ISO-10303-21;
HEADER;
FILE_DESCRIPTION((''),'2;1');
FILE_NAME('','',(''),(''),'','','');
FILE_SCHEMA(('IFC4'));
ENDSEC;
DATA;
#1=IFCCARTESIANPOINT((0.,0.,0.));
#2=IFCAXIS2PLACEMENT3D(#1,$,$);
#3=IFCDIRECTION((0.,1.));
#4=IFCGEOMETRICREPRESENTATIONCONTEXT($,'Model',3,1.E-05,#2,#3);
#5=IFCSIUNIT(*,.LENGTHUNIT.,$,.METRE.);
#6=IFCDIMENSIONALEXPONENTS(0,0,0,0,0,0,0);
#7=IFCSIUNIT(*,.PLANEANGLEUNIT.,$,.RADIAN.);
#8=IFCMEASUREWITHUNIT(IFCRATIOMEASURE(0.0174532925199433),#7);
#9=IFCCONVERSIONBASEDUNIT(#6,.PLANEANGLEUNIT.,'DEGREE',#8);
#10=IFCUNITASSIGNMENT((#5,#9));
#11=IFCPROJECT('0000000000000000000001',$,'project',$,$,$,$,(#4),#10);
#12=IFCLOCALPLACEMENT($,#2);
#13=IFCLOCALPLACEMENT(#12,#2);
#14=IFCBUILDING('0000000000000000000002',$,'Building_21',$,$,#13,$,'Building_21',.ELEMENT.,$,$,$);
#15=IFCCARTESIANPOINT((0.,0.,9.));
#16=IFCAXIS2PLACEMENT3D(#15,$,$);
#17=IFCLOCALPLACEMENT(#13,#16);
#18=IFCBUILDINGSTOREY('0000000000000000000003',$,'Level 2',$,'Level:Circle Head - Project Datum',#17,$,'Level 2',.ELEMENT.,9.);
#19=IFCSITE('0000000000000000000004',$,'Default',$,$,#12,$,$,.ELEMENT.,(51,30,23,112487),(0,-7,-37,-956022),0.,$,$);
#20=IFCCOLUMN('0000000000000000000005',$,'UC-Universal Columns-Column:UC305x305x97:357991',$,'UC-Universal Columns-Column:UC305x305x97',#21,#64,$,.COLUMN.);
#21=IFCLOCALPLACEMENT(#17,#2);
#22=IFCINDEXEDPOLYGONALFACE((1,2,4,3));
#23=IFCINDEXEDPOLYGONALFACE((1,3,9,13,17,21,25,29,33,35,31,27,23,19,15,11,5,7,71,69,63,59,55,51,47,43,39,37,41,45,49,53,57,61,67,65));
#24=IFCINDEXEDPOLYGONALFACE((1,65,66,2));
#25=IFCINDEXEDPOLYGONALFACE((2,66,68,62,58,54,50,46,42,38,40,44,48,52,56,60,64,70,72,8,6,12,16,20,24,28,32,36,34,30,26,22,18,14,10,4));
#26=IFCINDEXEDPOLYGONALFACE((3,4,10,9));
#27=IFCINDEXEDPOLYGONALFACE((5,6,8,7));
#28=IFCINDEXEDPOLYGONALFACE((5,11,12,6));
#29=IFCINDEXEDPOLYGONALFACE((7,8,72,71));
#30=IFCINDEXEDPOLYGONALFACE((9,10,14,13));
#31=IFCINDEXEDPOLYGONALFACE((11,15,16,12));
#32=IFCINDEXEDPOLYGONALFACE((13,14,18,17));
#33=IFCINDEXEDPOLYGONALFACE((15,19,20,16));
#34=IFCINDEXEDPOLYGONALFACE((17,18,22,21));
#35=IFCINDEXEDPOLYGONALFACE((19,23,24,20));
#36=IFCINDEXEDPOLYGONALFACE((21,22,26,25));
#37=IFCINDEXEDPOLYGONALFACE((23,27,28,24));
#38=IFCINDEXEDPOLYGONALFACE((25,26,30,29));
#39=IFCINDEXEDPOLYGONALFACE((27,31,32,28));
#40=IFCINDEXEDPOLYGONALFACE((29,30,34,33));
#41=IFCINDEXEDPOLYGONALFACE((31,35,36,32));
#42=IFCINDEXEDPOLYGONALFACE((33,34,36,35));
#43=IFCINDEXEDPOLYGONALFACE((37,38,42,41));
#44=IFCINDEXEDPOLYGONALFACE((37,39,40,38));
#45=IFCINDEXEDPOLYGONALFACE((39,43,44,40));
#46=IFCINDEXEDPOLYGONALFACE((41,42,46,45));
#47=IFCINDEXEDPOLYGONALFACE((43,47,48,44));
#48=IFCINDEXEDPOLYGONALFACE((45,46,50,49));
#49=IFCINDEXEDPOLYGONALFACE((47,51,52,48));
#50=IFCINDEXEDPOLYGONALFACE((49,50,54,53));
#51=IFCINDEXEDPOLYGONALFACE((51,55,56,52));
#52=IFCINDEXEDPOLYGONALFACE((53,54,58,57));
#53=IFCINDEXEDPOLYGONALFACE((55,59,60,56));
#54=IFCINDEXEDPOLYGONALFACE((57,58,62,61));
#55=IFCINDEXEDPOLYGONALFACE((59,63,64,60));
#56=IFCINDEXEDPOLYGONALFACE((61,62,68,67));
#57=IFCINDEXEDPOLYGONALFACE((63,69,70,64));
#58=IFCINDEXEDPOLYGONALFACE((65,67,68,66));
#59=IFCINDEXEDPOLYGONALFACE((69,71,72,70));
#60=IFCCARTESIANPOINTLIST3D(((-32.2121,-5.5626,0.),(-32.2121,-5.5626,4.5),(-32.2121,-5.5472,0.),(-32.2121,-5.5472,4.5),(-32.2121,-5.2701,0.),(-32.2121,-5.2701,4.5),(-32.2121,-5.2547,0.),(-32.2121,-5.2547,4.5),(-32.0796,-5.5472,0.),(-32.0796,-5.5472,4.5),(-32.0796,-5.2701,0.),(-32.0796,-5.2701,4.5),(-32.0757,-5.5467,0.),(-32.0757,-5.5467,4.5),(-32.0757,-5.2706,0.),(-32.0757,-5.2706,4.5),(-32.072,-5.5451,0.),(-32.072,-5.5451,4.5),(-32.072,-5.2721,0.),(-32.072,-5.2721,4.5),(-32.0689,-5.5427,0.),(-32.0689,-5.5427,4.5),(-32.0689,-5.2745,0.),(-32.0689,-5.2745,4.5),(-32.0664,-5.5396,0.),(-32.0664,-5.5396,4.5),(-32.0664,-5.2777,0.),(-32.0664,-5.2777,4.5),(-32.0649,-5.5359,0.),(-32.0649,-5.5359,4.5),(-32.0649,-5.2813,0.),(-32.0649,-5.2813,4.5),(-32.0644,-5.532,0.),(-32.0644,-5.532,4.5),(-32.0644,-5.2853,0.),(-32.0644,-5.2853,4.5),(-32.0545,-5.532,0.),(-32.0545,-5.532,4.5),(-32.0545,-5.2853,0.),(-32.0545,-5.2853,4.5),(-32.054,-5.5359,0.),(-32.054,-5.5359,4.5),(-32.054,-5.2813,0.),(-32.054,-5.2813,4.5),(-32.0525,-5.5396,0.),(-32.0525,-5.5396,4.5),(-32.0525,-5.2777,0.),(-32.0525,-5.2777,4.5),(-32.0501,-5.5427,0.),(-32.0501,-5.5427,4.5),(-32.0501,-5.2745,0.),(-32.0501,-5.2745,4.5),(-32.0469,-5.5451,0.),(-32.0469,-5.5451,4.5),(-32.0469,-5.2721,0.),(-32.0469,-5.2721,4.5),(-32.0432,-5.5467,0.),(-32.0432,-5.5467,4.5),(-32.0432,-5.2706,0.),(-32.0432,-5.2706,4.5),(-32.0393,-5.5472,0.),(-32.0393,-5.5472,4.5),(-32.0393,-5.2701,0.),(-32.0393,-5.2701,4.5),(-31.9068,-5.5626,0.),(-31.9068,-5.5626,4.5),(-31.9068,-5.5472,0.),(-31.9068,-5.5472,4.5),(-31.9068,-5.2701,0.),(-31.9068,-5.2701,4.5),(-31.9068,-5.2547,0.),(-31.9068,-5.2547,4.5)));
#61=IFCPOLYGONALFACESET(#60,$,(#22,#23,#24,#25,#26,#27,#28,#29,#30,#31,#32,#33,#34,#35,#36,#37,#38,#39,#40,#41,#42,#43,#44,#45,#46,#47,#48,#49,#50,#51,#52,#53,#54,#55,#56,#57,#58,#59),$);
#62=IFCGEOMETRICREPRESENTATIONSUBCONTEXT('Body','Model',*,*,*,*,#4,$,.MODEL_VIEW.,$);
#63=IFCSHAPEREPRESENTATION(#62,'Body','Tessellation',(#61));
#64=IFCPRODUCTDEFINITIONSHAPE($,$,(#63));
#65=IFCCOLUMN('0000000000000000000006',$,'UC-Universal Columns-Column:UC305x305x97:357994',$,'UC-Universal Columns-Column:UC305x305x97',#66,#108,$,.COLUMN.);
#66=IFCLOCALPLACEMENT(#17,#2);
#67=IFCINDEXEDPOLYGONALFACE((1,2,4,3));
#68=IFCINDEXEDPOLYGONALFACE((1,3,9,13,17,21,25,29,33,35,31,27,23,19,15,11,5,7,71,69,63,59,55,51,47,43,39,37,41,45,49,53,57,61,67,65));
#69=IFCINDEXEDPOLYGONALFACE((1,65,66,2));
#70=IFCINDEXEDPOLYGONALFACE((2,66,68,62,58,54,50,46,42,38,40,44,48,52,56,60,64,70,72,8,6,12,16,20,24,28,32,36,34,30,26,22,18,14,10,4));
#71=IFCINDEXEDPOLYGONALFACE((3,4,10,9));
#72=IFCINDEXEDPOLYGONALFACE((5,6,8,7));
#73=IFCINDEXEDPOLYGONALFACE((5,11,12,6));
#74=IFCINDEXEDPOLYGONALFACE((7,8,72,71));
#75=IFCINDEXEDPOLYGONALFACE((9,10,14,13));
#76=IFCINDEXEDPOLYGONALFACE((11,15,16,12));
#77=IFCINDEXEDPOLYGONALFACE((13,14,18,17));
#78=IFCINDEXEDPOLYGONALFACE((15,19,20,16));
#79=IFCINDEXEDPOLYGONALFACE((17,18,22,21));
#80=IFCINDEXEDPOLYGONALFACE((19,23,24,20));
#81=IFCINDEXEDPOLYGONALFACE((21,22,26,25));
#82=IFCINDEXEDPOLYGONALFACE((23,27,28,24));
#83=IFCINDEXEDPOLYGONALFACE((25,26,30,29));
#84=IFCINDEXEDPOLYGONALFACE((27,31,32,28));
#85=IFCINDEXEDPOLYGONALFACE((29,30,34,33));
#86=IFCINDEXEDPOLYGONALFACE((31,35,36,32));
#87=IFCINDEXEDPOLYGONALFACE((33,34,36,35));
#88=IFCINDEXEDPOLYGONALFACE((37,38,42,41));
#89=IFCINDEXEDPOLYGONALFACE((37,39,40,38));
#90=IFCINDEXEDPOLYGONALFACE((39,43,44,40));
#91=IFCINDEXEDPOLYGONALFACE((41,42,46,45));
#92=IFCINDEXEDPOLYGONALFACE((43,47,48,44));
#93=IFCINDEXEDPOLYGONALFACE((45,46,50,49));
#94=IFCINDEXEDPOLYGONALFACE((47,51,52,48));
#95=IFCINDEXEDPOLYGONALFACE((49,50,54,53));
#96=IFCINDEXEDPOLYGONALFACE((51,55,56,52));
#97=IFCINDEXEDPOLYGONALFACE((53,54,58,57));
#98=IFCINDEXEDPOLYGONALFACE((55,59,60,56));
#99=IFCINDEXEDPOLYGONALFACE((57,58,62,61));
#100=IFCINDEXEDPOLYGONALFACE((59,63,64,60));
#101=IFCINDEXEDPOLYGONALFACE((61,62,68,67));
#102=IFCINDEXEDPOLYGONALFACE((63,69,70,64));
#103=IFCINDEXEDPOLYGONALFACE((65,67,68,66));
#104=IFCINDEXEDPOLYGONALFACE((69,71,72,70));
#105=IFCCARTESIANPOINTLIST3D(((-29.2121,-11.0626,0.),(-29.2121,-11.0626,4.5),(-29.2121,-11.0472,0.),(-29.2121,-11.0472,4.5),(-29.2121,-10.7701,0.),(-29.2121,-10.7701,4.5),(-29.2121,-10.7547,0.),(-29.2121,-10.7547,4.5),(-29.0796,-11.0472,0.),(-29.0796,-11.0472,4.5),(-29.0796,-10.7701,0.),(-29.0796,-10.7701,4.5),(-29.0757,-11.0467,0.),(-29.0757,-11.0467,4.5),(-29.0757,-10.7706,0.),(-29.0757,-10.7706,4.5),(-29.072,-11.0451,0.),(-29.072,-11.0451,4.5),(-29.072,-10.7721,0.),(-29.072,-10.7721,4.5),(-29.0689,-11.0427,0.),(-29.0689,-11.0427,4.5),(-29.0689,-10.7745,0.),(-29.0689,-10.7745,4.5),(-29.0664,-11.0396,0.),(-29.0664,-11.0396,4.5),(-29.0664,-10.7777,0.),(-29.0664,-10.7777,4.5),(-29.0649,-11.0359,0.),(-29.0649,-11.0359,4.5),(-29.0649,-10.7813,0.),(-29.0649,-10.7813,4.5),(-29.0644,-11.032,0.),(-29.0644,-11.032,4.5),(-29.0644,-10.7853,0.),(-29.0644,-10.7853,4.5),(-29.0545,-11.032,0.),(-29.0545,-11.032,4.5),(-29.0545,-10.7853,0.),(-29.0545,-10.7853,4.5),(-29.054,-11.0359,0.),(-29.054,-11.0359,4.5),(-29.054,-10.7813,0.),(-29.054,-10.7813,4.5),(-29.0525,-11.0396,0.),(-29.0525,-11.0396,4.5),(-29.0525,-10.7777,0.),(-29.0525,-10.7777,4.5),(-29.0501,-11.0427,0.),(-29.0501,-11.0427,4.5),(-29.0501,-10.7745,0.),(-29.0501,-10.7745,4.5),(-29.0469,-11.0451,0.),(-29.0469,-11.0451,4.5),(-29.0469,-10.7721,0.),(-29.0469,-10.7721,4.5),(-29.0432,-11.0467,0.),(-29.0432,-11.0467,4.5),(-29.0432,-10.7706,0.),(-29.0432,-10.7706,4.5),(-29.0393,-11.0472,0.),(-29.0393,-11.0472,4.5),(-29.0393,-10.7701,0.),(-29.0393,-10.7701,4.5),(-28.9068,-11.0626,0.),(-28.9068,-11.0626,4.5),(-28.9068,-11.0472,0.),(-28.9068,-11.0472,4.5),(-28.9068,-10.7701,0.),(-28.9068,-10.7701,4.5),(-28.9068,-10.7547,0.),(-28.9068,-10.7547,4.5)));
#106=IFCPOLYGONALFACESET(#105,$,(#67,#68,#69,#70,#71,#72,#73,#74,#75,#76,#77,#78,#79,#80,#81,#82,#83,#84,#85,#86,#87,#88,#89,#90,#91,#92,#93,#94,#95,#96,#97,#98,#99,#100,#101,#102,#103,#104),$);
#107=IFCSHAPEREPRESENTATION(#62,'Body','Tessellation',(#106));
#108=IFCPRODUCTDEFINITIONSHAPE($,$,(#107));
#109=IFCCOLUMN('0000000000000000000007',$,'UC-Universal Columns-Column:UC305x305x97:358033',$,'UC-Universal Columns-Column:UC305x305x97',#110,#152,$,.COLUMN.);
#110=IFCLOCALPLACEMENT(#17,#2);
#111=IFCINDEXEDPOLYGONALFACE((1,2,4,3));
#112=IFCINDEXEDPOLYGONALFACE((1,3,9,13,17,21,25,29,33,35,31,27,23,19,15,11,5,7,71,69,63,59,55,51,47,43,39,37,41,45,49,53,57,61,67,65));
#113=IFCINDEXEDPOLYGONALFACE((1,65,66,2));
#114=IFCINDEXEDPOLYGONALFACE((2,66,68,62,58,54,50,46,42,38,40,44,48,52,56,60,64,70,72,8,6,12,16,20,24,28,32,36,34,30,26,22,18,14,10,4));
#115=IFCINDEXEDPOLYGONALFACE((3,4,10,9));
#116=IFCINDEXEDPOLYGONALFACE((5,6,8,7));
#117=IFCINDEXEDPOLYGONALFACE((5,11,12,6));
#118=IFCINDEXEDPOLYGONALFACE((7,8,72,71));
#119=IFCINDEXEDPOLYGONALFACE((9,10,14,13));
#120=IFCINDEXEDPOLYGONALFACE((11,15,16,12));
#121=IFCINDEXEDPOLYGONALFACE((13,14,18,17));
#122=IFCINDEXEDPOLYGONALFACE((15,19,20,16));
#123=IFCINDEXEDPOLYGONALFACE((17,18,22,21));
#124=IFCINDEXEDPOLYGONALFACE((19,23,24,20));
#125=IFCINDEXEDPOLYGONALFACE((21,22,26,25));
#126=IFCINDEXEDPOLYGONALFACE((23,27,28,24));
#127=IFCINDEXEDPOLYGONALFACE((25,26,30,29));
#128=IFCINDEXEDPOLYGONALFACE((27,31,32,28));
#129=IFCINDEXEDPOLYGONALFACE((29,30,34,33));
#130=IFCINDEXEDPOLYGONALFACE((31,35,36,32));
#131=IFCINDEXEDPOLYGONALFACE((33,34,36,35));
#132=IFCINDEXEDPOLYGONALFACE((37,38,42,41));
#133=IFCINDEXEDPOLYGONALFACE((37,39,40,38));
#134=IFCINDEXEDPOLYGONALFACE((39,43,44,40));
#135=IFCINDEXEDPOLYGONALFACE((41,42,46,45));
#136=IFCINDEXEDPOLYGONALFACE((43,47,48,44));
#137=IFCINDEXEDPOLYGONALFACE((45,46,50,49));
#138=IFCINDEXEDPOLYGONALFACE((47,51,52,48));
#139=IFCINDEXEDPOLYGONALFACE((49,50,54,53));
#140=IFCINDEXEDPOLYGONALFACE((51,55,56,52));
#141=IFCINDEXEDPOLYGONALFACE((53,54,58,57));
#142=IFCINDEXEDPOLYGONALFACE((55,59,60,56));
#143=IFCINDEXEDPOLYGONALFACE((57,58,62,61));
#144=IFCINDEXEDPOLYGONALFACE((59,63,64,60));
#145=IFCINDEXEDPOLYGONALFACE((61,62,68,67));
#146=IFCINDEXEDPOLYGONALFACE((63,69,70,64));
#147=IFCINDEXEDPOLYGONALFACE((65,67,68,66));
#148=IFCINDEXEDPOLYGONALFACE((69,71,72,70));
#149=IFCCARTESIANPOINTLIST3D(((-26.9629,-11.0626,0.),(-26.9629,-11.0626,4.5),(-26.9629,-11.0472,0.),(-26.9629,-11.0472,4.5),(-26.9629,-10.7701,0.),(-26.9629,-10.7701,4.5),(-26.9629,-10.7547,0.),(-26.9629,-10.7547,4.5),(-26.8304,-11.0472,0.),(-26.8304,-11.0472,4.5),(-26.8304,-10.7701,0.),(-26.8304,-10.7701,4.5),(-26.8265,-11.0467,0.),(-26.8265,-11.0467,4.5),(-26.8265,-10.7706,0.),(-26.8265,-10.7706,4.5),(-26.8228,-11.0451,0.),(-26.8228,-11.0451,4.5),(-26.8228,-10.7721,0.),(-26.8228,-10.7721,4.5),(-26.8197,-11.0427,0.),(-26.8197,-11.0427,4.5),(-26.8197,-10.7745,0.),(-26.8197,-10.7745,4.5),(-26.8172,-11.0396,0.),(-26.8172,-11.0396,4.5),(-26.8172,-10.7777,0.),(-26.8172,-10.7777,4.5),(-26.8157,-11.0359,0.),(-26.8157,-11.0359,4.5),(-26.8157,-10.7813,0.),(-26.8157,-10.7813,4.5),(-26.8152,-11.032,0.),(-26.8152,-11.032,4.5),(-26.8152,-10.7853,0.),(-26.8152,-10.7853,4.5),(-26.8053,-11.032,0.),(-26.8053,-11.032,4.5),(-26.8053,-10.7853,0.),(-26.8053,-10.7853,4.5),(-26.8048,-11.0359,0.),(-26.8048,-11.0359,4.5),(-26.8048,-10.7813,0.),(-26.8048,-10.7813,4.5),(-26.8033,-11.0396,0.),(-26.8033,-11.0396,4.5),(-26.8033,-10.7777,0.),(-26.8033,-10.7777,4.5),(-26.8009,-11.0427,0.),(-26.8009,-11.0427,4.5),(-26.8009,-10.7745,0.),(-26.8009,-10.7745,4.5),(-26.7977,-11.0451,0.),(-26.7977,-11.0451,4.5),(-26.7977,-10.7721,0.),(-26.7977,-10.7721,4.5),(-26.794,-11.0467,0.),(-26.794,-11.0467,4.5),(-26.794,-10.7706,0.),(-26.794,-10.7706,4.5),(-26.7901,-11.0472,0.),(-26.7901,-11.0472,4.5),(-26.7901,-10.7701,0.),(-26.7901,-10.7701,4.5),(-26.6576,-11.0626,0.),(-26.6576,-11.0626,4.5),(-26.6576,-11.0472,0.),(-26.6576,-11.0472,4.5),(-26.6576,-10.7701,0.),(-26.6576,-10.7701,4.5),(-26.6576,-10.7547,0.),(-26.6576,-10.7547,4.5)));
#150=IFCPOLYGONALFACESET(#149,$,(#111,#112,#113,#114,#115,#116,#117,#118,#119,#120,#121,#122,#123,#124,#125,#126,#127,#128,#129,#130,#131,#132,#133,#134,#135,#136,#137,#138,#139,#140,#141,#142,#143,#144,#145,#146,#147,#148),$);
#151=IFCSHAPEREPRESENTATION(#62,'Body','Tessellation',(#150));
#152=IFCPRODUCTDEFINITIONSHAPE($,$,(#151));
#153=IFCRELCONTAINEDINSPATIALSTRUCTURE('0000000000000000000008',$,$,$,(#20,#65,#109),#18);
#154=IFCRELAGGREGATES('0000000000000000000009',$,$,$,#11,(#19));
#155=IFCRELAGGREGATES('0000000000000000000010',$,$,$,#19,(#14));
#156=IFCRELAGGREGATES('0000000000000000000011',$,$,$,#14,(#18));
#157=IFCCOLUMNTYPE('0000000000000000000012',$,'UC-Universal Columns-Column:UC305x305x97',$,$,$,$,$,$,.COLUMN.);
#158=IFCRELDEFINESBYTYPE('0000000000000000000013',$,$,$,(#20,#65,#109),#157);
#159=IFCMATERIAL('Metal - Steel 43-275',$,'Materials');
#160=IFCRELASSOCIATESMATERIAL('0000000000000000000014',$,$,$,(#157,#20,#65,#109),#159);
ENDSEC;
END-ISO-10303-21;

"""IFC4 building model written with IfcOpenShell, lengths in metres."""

from ifc_helpers import new_model, entity, si_unit, converted_unit, direction, frame, frame_2d, origin, place, context, subcontext, project, spatial, polyline, circle_curve, parameter, trimmed, segment, composite_curve, i_section, outline, extrude, source, transform, mapped, material, material_profile, profile_set, profile_usage, type_object, type_shapes, element, save


model = new_model("IFC4")

# Units and contexts
model_context = context("Model", 3, precision=1e-05, world=origin(), true_north=direction((0.0, 1.0)))
body_context = subcontext(model_context, "Body", "Model", "MODEL_VIEW")
ifc_project = project(units=[si_unit("LENGTHUNIT", "METRE"), converted_unit("PLANEANGLEUNIT", "DEGREE", entity("IfcRatioMeasure", 0.0174532925199433), si_unit("PLANEANGLEUNIT", "RADIAN"), dimensions=[0, 0, 0, 0, 0, 0, 0])], contexts=[model_context])

# Site, building, storey
site_placement = place(None, origin())
site = spatial("IfcSite", under=ifc_project, at=site_placement, Name="Default", CompositionType="ELEMENT", RefLatitude=(51, 30, 23, 112487), RefLongitude=(0, -7, -37, -956022), RefElevation=0.0)
building_placement = place(site_placement, origin())
building = spatial("IfcBuilding", under=site, at=building_placement, Name="Building_21", LongName="Building_21", CompositionType="ELEMENT")
storey_placement = place(building_placement, frame((0.0, 0.0, 9.0)))
storey = spatial("IfcBuildingStorey", under=building, at=storey_placement, Name="Level 2", ObjectType="Level:Circle Head - Project Datum", LongName="Level 2", CompositionType="ELEMENT", Elevation=9.0)

# Columns
ifc_material_1 = material(Name="Metal - Steel 43-275", Category="Materials")
ifc_material_profile_1 = material_profile(ifc_material_1, outline(composite_curve([segment(polyline([(-0.1527, 0.154, 0.0), (0.1527, 0.154, 0.0)]), True, "CONTINUOUS"), segment(polyline([(0.1527, 0.154, 0.0), (0.1527, 0.1386, 0.0)]), True, "CONTINUOUS"), segment(polyline([(0.1527, 0.1386, 0.0), (0.0201, 0.1386, 0.0)]), True, "CONTINUOUS"), segment(trimmed(circle_curve(frame((0.0201, 0.1234, 0.0)), 0.0152), [parameter(90.0)], [parameter(180.0)], True, "PARAMETER"), True, "CONTINUOUS"), segment(polyline([(0.0049, 0.1234, 0.0), (0.0049, -0.1234, 0.0)]), True, "CONTINUOUS"), segment(trimmed(circle_curve(frame((0.0201, -0.1234, 0.0)), 0.0152), [parameter(180.0)], [parameter(270.0)], True, "PARAMETER"), True, "CONTINUOUS"), segment(polyline([(0.0201, -0.1386, 0.0), (0.1527, -0.1386, 0.0)]), True, "CONTINUOUS"), segment(polyline([(0.1527, -0.1386, 0.0), (0.1527, -0.154, 0.0)]), True, "CONTINUOUS"), segment(polyline([(0.1527, -0.154, 0.0), (-0.1527, -0.154, 0.0)]), True, "CONTINUOUS"), segment(polyline([(-0.1527, -0.154, 0.0), (-0.1527, -0.1386, 0.0)]), True, "CONTINUOUS"), segment(polyline([(-0.1527, -0.1386, 0.0), (-0.0201, -0.1386, 0.0)]), True, "CONTINUOUS"), segment(trimmed(circle_curve(frame((-0.0201, -0.1234, 0.0)), 0.0152), [parameter(270.0)], [parameter(0.0)], True, "PARAMETER"), True, "CONTINUOUS"), segment(polyline([(-0.0049, -0.1234, 0.0), (-0.005, 0.1234, 0.0)]), True, "CONTINUOUS"), segment(trimmed(circle_curve(frame((-0.0201, 0.1234, 0.0)), 0.0152), [parameter(0.0)], [parameter(90.0)], True, "PARAMETER"), True, "CONTINUOUS"), segment(polyline([(-0.0201, 0.1386, 0.0), (-0.1527, 0.1386, 0.0)]), True, "CONTINUOUS"), segment(polyline([(-0.1527, 0.1386, 0.0), (-0.1527, 0.154, 0.0)]), True, "CONTINUOUS")], self_intersect=False), kind="CURVE"), Name="UC305x305x97")
ifc_material_profile_2 = material_profile(ifc_material_1, outline(composite_curve([segment(polyline([(0.1527, 0.154, 0.0), (0.1527, 0.1386, 0.0)]), True, "CONTINUOUS"), segment(polyline([(0.1527, 0.1386, 0.0), (0.0049, 0.1386, 0.0)]), True, "CONTINUOUS"), segment(polyline([(0.0049, 0.1386, 0.0), (0.0049, -0.1386, 0.0)]), True, "CONTINUOUS"), segment(polyline([(0.0049, -0.1386, 0.0), (0.1527, -0.1386, 0.0)]), True, "CONTINUOUS"), segment(polyline([(0.1527, -0.1386, 0.0), (0.1527, -0.154, 0.0)]), True, "CONTINUOUS"), segment(polyline([(0.1527, -0.154, 0.0), (-0.1527, -0.154, 0.0)]), True, "CONTINUOUS"), segment(polyline([(-0.1527, -0.154, 0.0), (-0.1527, -0.1386, 0.0)]), True, "CONTINUOUS"), segment(polyline([(-0.1527, -0.1386, 0.0), (-0.005, -0.1386, 0.0)]), True, "CONTINUOUS"), segment(polyline([(-0.005, -0.1386, 0.0), (-0.005, 0.1386, 0.0)]), True, "CONTINUOUS"), segment(polyline([(-0.005, 0.1386, 0.0), (-0.1527, 0.1386, 0.0)]), True, "CONTINUOUS"), segment(polyline([(-0.1527, 0.1386, 0.0), (-0.1527, 0.154, 0.0)]), True, "CONTINUOUS"), segment(polyline([(-0.1527, 0.154, 0.0), (0.1527, 0.154, 0.0)]), True, "CONTINUOUS")], self_intersect=False), kind="CURVE"), Name="UC305x305x97")
ifc_profile_set_1 = profile_set([ifc_material_profile_1, ifc_material_profile_2], Name="UC305x305x97")
ifc_profile_usage_1 = profile_usage(ifc_profile_set_1)
column_type = type_object("IfcColumnType", Name="UC-Universal Columns-Column:UC305x305x97", PredefinedType="COLUMN", material=ifc_profile_set_1)
shared_shape_1 = source(origin(), body_context, "Body", "SweptSolid", [
    extrude(i_section(OverallWidth=0.3053, OverallDepth=0.3079, WebThickness=0.0099, FlangeThickness=0.0154, FilletRadius=0.0152, at=frame_2d((0.0, 0.0), x_axis=(0.0, 1.0))), frame((0.0, 0.0, 9.0), z_axis=(0.0, 0.0, 1.0), x_axis=(0.0, -1.0, 0.0)), (0.0, 0.0, 1.0), 4.5),
])
type_shapes(column_type, [shared_shape_1])
column_1_placement = place(storey_placement, frame((-32.0595, -5.4086, -9.0)))
element("IfcColumn", 1, at=column_1_placement, inside=storey, type_object=column_type, material=ifc_profile_usage_1, Name="UC-Universal Columns-Column:UC305x305x97:357991", ObjectType="UC-Universal Columns-Column:UC305x305x97", PredefinedType="COLUMN", context=body_context, shape_type="MappedRepresentation", body=[
    mapped(shared_shape_1, transform((0.0, 0.0, 0.0), scale=1.0)),
])
ifc_profile_usage_2 = profile_usage(ifc_profile_set_1)
column_2_placement = place(storey_placement, frame((-29.0595, -10.9086, -9.0)))
element("IfcColumn", 2, at=column_2_placement, inside=storey, type_object=column_type, material=ifc_profile_usage_2, Name="UC-Universal Columns-Column:UC305x305x97:357994", ObjectType="UC-Universal Columns-Column:UC305x305x97", PredefinedType="COLUMN", context=body_context, shape_type="MappedRepresentation", body=[
    mapped(shared_shape_1, transform((0.0, 0.0, 0.0), scale=1.0)),
])
ifc_profile_usage_3 = profile_usage(ifc_profile_set_1)
column_3_placement = place(storey_placement, frame((-26.8103, -10.9086, -9.0)))
element("IfcColumn", 3, at=column_3_placement, inside=storey, type_object=column_type, material=ifc_profile_usage_3, Name="UC-Universal Columns-Column:UC305x305x97:358033", ObjectType="UC-Universal Columns-Column:UC305x305x97", PredefinedType="COLUMN", context=body_context, shape_type="MappedRepresentation", body=[
    mapped(shared_shape_1, transform((0.0, 0.0, 0.0), scale=1.0)),
])

save(model, "model.ifc")
